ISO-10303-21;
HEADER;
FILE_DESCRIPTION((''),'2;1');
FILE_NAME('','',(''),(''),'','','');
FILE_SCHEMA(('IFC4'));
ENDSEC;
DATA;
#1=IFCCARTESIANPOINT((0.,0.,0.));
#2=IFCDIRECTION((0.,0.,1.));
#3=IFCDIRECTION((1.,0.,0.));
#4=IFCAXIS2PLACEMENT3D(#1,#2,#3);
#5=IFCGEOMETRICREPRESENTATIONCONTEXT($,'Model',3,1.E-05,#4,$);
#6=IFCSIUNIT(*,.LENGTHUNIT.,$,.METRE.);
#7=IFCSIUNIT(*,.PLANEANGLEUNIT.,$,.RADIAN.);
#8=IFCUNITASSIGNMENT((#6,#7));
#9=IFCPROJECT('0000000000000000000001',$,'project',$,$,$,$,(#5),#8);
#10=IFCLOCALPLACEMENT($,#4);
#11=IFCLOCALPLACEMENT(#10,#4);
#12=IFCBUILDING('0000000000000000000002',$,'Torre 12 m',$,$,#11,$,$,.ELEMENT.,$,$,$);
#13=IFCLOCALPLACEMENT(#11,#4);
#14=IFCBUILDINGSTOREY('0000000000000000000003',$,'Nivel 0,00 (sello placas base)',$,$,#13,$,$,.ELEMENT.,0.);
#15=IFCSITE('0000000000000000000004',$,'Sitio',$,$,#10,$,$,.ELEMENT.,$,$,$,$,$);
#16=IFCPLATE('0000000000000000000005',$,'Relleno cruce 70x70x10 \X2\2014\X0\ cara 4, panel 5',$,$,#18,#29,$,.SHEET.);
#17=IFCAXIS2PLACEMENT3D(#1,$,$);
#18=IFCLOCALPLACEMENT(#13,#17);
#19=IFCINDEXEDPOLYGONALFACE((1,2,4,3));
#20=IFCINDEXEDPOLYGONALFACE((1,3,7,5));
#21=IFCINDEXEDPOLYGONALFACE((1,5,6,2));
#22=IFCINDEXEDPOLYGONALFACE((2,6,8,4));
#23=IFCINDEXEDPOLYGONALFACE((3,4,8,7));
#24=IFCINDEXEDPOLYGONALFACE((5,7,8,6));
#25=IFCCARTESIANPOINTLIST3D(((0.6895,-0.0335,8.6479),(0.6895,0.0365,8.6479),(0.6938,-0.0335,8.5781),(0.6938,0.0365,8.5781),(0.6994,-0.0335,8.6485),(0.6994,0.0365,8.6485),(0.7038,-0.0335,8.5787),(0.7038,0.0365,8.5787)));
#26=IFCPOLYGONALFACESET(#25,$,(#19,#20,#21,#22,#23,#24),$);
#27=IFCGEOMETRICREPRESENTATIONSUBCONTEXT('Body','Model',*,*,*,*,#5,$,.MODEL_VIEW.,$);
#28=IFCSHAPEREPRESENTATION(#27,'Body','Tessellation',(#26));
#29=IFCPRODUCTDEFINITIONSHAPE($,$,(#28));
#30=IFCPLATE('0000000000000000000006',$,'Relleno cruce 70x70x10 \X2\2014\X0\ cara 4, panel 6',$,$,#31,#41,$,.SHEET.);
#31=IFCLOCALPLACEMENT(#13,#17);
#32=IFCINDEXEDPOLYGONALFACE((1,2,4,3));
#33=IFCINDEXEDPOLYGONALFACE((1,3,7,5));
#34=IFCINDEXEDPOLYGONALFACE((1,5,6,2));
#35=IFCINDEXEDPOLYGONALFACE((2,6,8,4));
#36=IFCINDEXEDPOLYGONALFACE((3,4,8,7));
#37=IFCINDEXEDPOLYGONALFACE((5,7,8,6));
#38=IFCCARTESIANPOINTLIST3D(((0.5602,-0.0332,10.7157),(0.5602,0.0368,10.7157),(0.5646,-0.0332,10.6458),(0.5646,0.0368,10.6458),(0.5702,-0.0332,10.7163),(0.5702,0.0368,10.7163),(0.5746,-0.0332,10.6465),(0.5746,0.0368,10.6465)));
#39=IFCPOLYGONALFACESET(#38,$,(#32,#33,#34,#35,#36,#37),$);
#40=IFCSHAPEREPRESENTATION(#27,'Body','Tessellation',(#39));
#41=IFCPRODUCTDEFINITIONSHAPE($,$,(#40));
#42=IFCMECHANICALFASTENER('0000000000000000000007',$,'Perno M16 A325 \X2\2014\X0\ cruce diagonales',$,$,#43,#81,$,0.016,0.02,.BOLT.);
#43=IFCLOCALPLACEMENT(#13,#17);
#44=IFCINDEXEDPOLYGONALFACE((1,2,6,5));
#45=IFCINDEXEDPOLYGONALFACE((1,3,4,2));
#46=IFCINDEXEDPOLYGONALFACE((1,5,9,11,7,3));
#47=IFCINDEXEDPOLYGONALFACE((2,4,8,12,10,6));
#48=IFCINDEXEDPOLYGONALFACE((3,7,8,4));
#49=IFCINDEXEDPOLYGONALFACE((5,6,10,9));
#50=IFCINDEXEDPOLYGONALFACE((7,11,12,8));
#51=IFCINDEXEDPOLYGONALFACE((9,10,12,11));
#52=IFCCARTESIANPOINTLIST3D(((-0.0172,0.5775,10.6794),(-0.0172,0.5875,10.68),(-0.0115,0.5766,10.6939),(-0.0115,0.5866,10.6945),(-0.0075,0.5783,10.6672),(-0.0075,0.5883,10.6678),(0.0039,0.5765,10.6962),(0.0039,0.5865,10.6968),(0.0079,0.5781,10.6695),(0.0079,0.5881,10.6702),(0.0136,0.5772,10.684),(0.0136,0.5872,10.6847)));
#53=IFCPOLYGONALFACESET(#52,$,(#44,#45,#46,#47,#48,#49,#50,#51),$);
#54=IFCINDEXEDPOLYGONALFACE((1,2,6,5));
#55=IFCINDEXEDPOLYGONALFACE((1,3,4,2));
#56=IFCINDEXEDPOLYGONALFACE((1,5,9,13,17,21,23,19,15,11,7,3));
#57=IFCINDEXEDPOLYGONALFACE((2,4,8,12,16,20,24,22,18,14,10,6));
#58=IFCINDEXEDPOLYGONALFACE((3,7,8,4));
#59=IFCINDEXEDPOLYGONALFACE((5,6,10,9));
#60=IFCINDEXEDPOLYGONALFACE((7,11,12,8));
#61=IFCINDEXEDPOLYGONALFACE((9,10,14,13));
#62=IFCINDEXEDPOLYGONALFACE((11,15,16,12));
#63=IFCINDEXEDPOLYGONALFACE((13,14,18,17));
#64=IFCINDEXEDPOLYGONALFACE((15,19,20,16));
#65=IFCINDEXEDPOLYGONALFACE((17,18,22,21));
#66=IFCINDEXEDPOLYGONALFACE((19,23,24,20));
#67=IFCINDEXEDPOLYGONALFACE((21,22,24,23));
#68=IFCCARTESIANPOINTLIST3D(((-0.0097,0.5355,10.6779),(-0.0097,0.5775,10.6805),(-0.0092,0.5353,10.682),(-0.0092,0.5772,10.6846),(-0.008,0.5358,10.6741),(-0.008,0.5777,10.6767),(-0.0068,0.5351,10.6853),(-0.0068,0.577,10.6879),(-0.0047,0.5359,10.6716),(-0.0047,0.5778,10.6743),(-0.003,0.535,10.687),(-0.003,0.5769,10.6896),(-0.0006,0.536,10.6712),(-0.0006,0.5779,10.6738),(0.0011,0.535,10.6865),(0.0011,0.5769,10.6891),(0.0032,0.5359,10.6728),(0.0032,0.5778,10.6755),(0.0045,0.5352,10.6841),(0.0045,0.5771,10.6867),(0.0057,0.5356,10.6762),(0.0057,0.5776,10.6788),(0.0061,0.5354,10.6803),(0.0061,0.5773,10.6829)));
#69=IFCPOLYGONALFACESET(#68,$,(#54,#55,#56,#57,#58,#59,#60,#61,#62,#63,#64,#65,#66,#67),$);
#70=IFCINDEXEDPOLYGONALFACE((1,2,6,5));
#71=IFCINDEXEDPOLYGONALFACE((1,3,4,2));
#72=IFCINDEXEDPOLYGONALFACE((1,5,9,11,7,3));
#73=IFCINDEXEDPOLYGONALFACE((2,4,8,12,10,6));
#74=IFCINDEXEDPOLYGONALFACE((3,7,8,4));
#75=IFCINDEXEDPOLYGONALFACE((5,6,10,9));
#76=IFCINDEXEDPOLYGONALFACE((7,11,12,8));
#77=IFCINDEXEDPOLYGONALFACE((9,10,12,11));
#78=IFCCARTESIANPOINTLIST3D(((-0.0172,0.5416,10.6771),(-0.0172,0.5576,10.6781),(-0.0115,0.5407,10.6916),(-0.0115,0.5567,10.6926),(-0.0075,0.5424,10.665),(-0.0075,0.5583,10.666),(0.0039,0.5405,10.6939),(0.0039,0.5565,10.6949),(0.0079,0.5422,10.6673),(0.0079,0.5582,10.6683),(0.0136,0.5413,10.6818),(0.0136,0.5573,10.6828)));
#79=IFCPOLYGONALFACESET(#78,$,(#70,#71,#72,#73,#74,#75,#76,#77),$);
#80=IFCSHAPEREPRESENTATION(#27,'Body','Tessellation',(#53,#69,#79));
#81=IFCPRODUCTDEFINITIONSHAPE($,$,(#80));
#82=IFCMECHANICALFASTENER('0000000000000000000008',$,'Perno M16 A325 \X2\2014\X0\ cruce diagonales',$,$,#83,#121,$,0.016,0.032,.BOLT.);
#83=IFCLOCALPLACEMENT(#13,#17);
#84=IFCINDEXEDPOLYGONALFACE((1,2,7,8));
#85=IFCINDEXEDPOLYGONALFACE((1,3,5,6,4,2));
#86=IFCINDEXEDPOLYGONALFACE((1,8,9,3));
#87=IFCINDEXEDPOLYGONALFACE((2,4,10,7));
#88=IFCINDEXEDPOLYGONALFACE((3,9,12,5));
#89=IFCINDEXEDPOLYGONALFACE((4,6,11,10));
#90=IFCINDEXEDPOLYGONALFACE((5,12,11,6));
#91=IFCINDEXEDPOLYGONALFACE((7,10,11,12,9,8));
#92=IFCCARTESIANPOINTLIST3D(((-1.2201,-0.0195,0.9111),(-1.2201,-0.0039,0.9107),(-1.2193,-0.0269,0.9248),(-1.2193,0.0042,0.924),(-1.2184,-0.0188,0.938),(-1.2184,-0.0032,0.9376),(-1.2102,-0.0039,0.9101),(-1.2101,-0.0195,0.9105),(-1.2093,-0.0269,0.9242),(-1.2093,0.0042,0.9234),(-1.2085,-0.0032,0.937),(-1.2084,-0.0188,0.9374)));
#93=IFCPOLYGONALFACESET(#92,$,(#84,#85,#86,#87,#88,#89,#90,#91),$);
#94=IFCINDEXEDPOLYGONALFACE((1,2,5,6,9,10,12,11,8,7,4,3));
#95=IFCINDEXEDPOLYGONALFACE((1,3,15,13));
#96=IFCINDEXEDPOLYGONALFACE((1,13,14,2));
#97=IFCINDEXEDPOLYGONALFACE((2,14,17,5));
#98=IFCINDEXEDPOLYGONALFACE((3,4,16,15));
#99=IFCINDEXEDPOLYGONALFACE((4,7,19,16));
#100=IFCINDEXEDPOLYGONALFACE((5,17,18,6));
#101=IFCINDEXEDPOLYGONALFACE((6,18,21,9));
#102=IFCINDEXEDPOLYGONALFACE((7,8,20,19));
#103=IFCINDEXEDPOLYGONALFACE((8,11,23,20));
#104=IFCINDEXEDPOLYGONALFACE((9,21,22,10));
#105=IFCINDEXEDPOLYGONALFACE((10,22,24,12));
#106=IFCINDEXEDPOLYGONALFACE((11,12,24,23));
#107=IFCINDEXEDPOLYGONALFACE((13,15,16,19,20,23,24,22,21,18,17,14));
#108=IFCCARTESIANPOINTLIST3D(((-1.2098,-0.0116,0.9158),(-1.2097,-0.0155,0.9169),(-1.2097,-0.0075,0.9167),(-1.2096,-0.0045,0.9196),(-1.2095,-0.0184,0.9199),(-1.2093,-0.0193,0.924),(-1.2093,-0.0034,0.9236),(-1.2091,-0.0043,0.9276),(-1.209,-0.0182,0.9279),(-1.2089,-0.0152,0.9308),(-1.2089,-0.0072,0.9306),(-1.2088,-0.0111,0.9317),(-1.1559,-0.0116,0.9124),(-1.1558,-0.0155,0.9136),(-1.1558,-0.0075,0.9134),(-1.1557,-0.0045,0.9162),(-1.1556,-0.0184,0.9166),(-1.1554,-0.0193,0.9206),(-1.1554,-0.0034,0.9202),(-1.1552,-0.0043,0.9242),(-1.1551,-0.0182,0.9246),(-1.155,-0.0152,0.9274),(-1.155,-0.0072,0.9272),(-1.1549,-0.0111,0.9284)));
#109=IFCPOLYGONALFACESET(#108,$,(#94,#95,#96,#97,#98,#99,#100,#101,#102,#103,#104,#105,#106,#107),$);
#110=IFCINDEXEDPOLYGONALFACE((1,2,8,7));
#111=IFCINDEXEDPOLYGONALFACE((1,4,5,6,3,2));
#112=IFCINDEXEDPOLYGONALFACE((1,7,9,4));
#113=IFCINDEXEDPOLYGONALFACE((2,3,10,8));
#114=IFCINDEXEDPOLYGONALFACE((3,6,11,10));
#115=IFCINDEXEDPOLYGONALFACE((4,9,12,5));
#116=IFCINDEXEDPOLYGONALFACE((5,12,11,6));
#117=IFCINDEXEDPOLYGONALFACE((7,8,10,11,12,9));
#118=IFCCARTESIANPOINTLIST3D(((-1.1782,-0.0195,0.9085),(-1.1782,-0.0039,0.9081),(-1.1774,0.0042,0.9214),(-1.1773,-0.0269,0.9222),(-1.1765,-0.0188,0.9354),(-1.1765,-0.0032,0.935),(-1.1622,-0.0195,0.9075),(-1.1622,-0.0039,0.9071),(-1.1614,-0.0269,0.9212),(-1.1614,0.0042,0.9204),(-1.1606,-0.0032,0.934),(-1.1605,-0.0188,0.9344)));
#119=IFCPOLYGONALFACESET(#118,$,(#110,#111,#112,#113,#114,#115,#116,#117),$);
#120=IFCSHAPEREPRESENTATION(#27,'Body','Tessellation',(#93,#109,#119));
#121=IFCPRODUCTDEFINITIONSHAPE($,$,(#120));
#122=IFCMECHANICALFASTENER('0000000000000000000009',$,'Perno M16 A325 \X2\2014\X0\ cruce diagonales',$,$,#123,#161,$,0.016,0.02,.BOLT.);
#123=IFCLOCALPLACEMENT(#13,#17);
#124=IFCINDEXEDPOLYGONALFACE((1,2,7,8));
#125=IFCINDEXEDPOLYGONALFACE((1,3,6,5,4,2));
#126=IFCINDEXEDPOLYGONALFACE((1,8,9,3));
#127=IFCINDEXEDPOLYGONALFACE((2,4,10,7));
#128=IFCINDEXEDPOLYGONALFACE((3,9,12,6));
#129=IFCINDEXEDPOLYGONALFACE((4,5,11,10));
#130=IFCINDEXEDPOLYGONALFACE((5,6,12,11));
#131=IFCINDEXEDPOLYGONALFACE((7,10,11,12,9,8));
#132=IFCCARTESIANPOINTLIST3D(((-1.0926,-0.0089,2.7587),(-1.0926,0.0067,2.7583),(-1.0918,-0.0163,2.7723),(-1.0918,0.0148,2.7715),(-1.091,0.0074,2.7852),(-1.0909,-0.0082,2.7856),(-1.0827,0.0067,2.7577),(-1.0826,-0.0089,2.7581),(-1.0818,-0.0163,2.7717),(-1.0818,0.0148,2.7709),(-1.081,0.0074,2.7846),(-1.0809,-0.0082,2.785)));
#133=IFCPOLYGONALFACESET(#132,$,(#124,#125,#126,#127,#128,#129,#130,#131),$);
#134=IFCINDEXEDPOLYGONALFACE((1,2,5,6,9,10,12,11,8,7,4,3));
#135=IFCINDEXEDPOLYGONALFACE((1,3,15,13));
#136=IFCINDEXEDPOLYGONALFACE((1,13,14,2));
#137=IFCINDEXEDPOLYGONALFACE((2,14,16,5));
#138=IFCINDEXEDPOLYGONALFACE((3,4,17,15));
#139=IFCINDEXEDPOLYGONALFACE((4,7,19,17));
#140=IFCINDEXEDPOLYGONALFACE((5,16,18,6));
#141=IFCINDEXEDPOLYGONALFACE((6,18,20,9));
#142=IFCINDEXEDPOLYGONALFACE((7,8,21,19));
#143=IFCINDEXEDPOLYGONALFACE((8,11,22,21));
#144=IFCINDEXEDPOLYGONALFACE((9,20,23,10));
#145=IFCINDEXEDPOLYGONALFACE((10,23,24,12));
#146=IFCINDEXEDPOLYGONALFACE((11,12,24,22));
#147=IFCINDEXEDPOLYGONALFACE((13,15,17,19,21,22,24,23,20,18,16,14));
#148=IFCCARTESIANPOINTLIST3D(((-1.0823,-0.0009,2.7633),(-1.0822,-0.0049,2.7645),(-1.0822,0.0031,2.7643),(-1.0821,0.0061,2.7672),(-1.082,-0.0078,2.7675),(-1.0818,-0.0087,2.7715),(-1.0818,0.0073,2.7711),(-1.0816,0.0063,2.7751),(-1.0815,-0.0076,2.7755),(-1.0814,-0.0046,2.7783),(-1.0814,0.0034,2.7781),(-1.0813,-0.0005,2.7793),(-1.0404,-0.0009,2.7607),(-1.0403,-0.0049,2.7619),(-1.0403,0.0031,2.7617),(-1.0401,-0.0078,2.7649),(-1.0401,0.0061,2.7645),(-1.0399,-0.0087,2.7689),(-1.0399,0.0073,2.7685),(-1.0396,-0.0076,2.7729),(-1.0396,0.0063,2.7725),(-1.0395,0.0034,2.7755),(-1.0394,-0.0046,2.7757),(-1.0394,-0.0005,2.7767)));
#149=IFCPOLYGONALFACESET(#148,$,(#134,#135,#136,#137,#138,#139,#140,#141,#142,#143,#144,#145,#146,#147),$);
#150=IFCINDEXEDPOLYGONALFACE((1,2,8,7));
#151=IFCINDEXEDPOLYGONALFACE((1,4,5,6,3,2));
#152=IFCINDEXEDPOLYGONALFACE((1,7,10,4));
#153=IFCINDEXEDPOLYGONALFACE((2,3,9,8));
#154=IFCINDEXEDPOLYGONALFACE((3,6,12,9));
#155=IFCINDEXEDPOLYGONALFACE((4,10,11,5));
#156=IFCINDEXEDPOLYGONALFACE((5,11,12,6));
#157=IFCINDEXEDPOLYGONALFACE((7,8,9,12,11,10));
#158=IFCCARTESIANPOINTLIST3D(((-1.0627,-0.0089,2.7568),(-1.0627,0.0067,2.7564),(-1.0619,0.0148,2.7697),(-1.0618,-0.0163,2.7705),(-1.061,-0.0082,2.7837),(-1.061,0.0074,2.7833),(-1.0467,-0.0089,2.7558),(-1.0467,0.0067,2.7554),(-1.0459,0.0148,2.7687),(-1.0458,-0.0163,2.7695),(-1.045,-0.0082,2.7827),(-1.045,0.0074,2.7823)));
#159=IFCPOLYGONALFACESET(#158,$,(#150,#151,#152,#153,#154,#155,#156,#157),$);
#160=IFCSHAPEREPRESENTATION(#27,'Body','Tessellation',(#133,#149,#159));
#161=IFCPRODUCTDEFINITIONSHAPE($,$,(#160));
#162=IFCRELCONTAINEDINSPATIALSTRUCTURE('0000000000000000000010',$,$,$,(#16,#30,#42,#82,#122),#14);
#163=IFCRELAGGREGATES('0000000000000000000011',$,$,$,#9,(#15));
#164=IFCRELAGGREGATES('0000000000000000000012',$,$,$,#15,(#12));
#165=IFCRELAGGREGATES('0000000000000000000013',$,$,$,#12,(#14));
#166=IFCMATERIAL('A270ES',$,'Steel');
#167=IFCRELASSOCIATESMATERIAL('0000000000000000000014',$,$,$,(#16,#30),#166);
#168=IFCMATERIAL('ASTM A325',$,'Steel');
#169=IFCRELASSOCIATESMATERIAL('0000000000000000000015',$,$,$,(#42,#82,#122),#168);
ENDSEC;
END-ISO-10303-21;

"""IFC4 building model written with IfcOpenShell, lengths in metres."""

from ifc_helpers import new_model, si_unit, frame, origin_with_axes, place, context, subcontext, project, spatial, polyline, outline, extrude, material, element, save


model = new_model("IFC4")

# Units and contexts
model_context = context("Model", 3, precision=1e-05, world=origin_with_axes())
body_context = subcontext(model_context, "Body", "Model", "MODEL_VIEW")
ifc_project = project(units=[si_unit("LENGTHUNIT", "METRE"), si_unit("PLANEANGLEUNIT", "RADIAN")], contexts=[model_context])

# Site, building, storey
site_placement = place(None, origin_with_axes())
site = spatial("IfcSite", under=ifc_project, at=site_placement, Name="Sitio", CompositionType="ELEMENT")
building_placement = place(site_placement, origin_with_axes())
building = spatial("IfcBuilding", under=site, at=building_placement, Name="Torre 12 m", CompositionType="ELEMENT")
storey_placement = place(building_placement, origin_with_axes())
storey = spatial("IfcBuildingStorey", under=building, at=storey_placement, Name="Nivel 0,00 (sello placas base)", CompositionType="ELEMENT", Elevation=0.0)

# Plates
ifc_material_1 = material(Name="A270ES", Category="Steel")
placement = place(storey_placement, origin_with_axes())
element("IfcPlate", 1, at=placement, inside=storey, material=ifc_material_1, Name="Relleno cruce 70x70x10 — cara 4, panel 5", PredefinedType="SHEET", context=body_context, shape_type="SweptSolid", body=[
    extrude(outline(polyline([(-0.035, -0.035), (0.035, -0.035), (0.035, 0.035), (-0.035, 0.035), (-0.035, -0.035)])), frame((0.7016, 0.0015, 8.6136), z_axis=(-0.998053, 0.0, -0.062378), x_axis=(0.0, 1.0, 0.0)), (0.0, 0.0, 1.0), 0.01),
])
element("IfcPlate", 2, at=placement, inside=storey, material=ifc_material_1, Name="Relleno cruce 70x70x10 — cara 4, panel 6", PredefinedType="SHEET", context=body_context, shape_type="SweptSolid", body=[
    extrude(outline(polyline([(-0.035, -0.035), (0.035, -0.035), (0.035, 0.035), (-0.035, 0.035), (-0.035, -0.035)])), frame((0.5724, 0.0018, 10.6814), z_axis=(-0.998053, 0.0, -0.062378), x_axis=(0.0, 1.0, 0.0)), (0.0, 0.0, 1.0), 0.01),
])

# Mechanical fasteners
ifc_material_2 = material(Name="ASTM A325", Category="Steel")
element("IfcMechanicalFastener", 3, at=placement, inside=storey, material=ifc_material_2, Name="Perno M16 A325 — cruce diagonales", NominalDiameter=0.016, NominalLength=0.02, PredefinedType="BOLT", context=body_context, shape_type="SweptSolid", body=[
    extrude(outline(polyline([(0.0135, 0.0078), (0.0, 0.0156), (-0.0135, 0.0078), (-0.0135, -0.0078), (0.0, -0.0156), (0.0135, -0.0078), (0.0135, 0.0078)])), frame((-0.0018, 0.5874, 10.6823), z_axis=(0.0, -0.998053, -0.062378), x_axis=(-0.931337, -0.022716, 0.363449)), (0.0, 0.0, 1.0), 0.01),
    extrude(outline(polyline([(0.008, 0.0), (0.0069, 0.004), (0.004, 0.0069), (0.0, 0.008), (-0.004, 0.0069), (-0.0069, 0.004), (-0.008, 0.0), (-0.0069, -0.004), (-0.004, -0.0069), (0.0, -0.008), (0.004, -0.0069), (0.0069, -0.004), (0.008, 0.0)])), frame((-0.0018, 0.5774, 10.6817), z_axis=(0.0, -0.998053, -0.062378), x_axis=(-0.931337, -0.022716, 0.363449)), (0.0, 0.0, 1.0), 0.042),
    extrude(outline(polyline([(0.0135, 0.0078), (0.0, 0.0156), (-0.0135, 0.0078), (-0.0135, -0.0078), (0.0, -0.0156), (0.0135, -0.0078), (0.0135, 0.0078)])), frame((-0.0018, 0.5574, 10.6805), z_axis=(0.0, -0.998053, -0.062378), x_axis=(-0.931337, -0.022716, 0.363449)), (0.0, 0.0, 1.0), 0.016),
])
element("IfcMechanicalFastener", 4, at=placement, inside=storey, material=ifc_material_2, Name="Perno M16 A325 — cruce diagonales", NominalDiameter=0.016, NominalLength=0.032, PredefinedType="BOLT", context=body_context, shape_type="SweptSolid", body=[
    extrude(outline(polyline([(0.0135, 0.0078), (0.0, 0.0156), (-0.0135, 0.0078), (-0.0135, -0.0078), (0.0, -0.0156), (0.0135, -0.0078), (0.0135, 0.0078)])), frame((-1.2193, -0.0113, 0.9244), z_axis=(0.998053, 0.0, -0.062378), x_axis=(0.032557, -0.85299, 0.52091)), (0.0, 0.0, 1.0), 0.01),
    extrude(outline(polyline([(0.008, 0.0), (0.0069, 0.004), (0.004, 0.0069), (0.0, 0.008), (-0.004, 0.0069), (-0.0069, 0.004), (-0.008, 0.0), (-0.0069, -0.004), (-0.004, -0.0069), (0.0, -0.008), (0.004, -0.0069), (0.0069, -0.004), (0.008, 0.0)])), frame((-1.2093, -0.0113, 0.9238), z_axis=(0.998053, 0.0, -0.062378), x_axis=(0.032557, -0.85299, 0.52091)), (0.0, 0.0, 1.0), 0.054),
    extrude(outline(polyline([(0.0135, 0.0078), (0.0, 0.0156), (-0.0135, 0.0078), (-0.0135, -0.0078), (0.0, -0.0156), (0.0135, -0.0078), (0.0135, 0.0078)])), frame((-1.1774, -0.0113, 0.9218), z_axis=(0.998053, 0.0, -0.062378), x_axis=(0.032557, -0.85299, 0.52091)), (0.0, 0.0, 1.0), 0.016),
])
element("IfcMechanicalFastener", 5, at=placement, inside=storey, material=ifc_material_2, Name="Perno M16 A325 — cruce diagonales", NominalDiameter=0.016, NominalLength=0.02, PredefinedType="BOLT", context=body_context, shape_type="SweptSolid", body=[
    extrude(outline(polyline([(0.0135, 0.0078), (0.0, 0.0156), (-0.0135, 0.0078), (-0.0135, -0.0078), (0.0, -0.0156), (0.0135, -0.0078), (0.0135, 0.0078)])), frame((-1.0918, -0.0007, 2.7719), z_axis=(0.998053, 0.0, -0.062378), x_axis=(0.032557, -0.85299, 0.52091)), (0.0, 0.0, 1.0), 0.01),
    extrude(outline(polyline([(0.008, 0.0), (0.0069, 0.004), (0.004, 0.0069), (0.0, 0.008), (-0.004, 0.0069), (-0.0069, 0.004), (-0.008, 0.0), (-0.0069, -0.004), (-0.004, -0.0069), (0.0, -0.008), (0.004, -0.0069), (0.0069, -0.004), (0.008, 0.0)])), frame((-1.0818, -0.0007, 2.7713), z_axis=(0.998053, 0.0, -0.062378), x_axis=(0.032557, -0.85299, 0.52091)), (0.0, 0.0, 1.0), 0.042),
    extrude(outline(polyline([(0.0135, 0.0078), (0.0, 0.0156), (-0.0135, 0.0078), (-0.0135, -0.0078), (0.0, -0.0156), (0.0135, -0.0078), (0.0135, 0.0078)])), frame((-1.0618, -0.0007, 2.7701), z_axis=(0.998053, 0.0, -0.062378), x_axis=(0.032557, -0.85299, 0.52091)), (0.0, 0.0, 1.0), 0.016),
])

save(model, "model.ifc")
